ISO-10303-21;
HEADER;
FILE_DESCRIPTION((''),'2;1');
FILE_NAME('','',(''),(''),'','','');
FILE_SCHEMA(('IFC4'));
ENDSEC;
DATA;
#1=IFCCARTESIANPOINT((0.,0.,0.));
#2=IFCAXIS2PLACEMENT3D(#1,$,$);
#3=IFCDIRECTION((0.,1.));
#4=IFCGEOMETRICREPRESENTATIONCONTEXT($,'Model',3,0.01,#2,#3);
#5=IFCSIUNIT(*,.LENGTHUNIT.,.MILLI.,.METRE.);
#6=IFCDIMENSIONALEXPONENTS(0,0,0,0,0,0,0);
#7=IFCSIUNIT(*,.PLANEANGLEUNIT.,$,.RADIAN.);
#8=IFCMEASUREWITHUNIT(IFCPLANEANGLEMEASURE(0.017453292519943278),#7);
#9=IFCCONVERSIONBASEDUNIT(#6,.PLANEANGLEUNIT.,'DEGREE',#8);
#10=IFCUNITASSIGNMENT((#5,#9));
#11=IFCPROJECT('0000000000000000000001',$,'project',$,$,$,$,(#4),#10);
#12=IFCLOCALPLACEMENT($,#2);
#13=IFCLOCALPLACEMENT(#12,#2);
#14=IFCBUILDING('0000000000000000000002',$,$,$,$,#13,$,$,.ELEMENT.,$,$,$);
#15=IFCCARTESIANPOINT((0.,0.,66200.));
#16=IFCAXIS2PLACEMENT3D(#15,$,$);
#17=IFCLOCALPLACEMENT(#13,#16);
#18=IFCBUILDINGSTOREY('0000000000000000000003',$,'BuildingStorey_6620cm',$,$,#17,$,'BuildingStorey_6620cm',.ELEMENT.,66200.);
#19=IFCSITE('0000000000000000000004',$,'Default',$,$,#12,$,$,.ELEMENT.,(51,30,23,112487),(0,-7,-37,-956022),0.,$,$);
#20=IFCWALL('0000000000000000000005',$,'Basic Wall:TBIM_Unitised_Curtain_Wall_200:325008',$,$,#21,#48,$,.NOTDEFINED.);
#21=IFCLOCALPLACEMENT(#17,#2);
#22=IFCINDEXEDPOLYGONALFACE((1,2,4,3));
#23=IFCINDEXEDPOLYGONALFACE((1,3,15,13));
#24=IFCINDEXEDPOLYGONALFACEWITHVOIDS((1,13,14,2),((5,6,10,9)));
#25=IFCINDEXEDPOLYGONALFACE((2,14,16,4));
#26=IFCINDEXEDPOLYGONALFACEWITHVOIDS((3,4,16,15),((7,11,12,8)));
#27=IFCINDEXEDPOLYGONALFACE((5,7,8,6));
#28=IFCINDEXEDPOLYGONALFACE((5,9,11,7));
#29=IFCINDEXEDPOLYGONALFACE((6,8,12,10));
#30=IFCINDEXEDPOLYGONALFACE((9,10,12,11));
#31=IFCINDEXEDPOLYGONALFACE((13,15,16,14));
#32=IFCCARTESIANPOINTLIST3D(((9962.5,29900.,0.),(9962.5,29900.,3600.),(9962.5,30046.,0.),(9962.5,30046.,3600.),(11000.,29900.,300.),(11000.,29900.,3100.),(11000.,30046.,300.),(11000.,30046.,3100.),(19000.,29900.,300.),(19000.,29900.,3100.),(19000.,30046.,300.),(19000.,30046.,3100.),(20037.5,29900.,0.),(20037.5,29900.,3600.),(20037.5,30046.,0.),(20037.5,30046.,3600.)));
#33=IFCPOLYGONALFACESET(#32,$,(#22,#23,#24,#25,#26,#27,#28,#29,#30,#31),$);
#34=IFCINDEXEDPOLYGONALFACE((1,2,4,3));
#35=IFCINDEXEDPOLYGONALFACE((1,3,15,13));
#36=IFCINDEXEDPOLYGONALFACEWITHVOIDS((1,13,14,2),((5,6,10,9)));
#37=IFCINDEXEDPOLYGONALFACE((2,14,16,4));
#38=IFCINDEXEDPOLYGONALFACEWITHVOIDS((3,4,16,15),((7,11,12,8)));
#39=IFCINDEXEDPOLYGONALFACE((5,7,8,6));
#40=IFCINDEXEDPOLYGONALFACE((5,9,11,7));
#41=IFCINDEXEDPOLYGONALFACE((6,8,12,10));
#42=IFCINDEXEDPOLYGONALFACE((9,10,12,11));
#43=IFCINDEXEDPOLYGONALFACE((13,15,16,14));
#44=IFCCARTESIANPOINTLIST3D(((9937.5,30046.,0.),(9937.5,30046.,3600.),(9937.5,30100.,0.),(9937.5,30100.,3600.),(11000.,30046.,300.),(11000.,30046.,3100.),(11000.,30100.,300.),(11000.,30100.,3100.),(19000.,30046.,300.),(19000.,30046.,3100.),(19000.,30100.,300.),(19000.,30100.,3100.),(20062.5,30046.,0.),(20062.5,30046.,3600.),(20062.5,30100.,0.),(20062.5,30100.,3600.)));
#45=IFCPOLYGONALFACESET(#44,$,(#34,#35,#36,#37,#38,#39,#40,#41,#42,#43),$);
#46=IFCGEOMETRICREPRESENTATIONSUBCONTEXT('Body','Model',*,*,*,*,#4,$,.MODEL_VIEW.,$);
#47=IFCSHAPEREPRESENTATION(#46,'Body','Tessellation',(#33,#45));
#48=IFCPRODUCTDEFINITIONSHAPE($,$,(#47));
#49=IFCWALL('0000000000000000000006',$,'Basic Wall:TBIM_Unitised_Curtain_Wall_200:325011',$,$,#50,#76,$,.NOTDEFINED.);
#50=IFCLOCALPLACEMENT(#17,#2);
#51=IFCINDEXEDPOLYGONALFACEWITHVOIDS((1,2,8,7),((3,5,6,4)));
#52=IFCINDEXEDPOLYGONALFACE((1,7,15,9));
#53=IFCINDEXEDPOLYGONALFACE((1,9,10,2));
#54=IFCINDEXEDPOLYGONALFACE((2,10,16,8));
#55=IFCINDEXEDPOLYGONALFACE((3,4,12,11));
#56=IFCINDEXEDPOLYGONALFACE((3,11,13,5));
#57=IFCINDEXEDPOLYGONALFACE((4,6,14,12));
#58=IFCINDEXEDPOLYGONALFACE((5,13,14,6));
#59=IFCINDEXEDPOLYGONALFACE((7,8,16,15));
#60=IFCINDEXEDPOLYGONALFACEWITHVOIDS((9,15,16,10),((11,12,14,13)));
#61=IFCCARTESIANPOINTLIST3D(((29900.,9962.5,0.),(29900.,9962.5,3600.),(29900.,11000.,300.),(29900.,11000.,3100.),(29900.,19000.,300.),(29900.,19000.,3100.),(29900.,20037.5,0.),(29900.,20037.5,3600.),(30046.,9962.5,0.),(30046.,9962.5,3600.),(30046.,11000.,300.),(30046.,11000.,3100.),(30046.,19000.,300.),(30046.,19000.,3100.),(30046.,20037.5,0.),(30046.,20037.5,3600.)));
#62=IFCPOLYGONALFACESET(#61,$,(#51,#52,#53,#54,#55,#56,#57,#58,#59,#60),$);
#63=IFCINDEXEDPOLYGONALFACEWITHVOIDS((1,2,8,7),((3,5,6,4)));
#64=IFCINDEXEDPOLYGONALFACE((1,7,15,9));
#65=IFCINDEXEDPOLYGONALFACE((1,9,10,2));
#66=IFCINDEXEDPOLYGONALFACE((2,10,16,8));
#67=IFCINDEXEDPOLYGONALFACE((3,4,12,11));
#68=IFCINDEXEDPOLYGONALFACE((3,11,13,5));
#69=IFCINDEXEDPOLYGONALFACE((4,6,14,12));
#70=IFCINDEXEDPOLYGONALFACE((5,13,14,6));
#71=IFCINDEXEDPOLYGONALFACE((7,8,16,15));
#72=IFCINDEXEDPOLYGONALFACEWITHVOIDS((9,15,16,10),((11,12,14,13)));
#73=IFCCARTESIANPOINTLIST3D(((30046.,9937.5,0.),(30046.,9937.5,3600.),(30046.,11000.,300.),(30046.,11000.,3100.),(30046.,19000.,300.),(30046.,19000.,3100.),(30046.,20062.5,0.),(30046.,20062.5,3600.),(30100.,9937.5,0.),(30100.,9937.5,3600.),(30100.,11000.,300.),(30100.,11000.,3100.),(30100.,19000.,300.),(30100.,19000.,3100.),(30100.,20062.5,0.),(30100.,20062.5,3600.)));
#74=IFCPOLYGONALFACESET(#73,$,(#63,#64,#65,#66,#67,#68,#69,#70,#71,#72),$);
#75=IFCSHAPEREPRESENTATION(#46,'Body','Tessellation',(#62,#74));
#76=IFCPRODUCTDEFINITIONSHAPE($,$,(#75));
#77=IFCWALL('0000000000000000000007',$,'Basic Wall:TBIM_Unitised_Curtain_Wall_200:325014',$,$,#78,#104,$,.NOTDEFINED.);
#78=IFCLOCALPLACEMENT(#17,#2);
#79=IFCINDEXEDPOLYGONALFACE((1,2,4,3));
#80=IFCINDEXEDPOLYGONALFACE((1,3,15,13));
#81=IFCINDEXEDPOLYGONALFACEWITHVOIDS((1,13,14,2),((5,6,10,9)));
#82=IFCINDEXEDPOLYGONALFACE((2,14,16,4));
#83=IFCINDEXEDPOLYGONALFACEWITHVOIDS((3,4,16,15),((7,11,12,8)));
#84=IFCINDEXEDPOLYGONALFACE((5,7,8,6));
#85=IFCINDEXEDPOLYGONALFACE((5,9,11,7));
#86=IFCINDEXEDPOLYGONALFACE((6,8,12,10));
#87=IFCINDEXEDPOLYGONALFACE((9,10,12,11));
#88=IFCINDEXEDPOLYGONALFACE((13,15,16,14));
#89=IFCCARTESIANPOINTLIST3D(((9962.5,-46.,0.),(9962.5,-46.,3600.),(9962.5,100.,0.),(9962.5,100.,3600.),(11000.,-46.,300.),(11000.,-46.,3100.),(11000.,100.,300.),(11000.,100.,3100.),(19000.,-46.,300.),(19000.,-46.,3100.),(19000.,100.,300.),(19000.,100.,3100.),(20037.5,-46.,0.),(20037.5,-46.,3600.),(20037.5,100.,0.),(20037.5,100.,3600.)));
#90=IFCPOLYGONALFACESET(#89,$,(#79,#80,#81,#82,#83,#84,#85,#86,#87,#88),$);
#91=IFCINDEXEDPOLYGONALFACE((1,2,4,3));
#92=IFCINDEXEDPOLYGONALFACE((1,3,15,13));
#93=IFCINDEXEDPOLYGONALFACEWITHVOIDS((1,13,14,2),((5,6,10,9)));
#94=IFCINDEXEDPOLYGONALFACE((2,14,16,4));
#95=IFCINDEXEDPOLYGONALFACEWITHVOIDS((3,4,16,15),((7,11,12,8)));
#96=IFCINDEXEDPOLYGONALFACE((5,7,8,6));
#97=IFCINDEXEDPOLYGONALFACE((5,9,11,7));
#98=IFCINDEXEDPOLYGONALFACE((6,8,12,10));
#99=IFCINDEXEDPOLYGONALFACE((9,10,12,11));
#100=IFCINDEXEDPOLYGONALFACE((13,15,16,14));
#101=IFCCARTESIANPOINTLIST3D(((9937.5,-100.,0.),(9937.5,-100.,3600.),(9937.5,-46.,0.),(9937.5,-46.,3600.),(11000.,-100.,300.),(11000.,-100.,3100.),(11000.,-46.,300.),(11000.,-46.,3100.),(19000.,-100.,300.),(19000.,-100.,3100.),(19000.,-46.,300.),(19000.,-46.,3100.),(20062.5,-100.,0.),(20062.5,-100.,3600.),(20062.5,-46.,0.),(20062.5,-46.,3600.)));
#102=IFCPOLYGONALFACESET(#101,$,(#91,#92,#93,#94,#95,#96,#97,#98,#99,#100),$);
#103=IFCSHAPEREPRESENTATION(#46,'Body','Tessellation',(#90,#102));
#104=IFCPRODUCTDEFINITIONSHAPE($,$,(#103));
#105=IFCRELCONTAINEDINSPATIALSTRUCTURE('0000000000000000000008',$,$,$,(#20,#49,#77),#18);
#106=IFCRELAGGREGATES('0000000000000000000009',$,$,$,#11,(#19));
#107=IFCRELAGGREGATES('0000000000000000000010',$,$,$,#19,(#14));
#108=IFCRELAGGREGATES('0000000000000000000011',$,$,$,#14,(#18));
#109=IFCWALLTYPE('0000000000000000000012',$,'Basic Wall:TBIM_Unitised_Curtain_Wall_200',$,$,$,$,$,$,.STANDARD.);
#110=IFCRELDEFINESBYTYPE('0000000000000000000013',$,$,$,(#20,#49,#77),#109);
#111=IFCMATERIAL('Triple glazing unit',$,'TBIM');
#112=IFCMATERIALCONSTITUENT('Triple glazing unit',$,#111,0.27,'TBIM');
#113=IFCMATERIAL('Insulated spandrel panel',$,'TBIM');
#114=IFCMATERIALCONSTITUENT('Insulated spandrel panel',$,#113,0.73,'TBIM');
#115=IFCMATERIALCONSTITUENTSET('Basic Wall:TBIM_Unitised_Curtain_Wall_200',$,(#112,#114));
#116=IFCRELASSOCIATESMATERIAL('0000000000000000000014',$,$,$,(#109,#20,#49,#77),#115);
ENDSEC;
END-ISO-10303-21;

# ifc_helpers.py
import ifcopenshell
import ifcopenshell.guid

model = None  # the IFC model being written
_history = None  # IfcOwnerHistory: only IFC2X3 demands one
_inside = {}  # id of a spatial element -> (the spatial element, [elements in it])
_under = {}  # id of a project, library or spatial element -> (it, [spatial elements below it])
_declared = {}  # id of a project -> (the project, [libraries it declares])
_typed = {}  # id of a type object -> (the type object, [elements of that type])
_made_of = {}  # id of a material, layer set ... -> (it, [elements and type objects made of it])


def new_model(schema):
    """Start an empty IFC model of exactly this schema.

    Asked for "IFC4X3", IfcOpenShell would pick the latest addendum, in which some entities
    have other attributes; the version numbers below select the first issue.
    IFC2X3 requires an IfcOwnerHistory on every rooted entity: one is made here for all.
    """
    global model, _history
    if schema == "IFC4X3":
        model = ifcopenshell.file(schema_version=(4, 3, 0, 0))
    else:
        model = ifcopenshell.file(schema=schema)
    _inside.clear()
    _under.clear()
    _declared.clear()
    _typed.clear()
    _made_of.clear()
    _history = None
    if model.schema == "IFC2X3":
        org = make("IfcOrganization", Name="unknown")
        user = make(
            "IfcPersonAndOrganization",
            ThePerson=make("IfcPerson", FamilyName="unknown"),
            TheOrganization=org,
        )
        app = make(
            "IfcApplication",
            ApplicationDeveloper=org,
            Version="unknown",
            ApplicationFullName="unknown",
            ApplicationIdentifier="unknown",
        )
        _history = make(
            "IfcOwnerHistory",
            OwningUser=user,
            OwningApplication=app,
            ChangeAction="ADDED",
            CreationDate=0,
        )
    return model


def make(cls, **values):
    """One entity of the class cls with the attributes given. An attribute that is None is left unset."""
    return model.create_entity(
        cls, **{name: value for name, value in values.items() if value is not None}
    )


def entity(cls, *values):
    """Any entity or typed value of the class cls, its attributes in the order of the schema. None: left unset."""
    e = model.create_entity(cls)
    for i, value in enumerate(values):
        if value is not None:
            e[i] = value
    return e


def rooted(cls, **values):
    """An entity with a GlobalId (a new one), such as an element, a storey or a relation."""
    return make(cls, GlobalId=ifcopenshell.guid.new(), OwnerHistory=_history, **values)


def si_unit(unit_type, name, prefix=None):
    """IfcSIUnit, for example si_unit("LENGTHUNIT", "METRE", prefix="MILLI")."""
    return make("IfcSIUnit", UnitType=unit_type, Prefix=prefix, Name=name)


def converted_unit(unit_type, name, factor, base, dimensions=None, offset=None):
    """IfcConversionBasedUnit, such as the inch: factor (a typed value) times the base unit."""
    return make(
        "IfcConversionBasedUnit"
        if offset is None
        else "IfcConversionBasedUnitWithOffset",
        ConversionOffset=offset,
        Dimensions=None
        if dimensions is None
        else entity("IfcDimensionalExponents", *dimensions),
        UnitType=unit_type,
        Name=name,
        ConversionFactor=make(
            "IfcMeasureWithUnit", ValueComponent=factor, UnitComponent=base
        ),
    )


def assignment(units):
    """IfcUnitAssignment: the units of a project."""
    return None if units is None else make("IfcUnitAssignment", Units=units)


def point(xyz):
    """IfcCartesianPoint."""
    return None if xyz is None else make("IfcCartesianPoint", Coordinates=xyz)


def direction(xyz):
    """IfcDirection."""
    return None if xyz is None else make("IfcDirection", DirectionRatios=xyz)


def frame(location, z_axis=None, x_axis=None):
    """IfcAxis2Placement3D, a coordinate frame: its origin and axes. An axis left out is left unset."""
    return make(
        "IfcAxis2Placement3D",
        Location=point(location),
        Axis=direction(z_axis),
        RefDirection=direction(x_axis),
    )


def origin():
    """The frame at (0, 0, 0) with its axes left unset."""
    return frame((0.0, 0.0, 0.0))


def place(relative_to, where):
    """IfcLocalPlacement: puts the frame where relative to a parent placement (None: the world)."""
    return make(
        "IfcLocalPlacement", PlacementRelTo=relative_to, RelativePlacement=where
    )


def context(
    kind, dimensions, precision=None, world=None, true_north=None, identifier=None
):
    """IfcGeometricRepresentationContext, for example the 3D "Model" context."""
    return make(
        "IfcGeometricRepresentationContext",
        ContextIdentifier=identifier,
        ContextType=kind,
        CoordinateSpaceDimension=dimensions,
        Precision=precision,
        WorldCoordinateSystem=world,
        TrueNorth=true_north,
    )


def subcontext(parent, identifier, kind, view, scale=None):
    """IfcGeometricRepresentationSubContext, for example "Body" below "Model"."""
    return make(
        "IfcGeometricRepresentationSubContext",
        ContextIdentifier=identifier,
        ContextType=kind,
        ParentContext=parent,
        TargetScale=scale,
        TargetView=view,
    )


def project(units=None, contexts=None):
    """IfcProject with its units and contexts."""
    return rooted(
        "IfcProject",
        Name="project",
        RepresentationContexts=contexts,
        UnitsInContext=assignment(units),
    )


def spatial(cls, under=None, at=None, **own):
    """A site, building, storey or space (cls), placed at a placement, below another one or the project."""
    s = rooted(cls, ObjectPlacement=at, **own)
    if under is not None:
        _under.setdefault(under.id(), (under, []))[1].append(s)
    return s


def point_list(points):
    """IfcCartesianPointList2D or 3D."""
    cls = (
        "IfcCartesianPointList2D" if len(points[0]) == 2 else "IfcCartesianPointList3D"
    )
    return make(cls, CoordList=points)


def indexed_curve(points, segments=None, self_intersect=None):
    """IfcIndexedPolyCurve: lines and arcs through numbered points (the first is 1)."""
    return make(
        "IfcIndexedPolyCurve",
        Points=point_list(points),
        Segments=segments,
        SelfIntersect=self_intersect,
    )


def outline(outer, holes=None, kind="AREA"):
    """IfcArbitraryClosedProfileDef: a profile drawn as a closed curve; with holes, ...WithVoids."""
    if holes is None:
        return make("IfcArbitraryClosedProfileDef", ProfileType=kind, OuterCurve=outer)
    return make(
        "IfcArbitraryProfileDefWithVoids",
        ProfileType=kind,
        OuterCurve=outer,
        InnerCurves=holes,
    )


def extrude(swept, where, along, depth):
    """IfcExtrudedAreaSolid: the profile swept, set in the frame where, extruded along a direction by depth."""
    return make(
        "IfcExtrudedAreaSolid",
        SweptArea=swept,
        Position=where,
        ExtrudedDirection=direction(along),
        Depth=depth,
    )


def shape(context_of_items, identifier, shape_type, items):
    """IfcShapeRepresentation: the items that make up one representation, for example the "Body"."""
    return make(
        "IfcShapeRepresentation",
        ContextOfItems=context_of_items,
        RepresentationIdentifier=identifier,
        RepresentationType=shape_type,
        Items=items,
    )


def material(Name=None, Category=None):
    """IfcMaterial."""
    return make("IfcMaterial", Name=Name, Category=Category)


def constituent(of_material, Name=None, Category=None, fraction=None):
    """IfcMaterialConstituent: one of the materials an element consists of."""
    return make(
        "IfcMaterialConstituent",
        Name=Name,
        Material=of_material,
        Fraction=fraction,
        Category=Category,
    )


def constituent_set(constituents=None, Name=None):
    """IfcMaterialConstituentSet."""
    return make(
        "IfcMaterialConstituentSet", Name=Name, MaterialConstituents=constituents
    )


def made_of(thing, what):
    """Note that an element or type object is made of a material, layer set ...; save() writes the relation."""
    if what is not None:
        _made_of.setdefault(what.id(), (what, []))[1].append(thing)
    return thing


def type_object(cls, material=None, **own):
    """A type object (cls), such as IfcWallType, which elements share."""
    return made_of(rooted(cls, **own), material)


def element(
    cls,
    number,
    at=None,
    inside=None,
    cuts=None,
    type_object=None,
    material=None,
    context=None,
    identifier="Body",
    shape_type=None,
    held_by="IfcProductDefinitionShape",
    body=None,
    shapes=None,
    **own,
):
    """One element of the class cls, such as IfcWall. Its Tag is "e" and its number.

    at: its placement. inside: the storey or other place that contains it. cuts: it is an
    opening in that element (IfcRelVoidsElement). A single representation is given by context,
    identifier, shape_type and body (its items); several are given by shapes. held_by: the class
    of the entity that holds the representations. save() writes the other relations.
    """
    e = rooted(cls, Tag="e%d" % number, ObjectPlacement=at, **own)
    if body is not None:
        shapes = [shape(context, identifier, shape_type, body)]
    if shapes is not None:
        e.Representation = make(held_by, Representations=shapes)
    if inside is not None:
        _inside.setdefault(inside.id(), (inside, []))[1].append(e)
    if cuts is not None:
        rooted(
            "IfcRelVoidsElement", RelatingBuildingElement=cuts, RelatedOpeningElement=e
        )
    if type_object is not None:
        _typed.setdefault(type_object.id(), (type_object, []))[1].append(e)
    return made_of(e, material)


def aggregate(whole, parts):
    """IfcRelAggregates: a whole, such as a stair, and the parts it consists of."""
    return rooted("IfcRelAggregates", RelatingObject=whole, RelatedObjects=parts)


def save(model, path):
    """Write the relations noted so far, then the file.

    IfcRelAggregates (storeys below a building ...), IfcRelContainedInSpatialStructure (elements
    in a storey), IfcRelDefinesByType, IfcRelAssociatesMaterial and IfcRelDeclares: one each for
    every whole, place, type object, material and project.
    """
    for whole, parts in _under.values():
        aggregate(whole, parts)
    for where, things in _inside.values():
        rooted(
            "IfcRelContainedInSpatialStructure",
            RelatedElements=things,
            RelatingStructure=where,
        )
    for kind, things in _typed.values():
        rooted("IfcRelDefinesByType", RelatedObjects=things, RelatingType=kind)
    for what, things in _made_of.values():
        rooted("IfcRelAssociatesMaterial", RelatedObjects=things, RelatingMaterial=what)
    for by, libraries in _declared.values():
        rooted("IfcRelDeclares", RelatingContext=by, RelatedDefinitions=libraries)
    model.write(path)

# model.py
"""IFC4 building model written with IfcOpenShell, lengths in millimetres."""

from ifc_helpers import new_model, entity, si_unit, converted_unit, direction, frame, origin, place, context, subcontext, project, spatial, indexed_curve, outline, extrude, material, constituent, constituent_set, type_object, element, save


model = new_model("IFC4")

# Units and contexts
model_context = context("Model", 3, precision=0.01, world=origin(), true_north=direction((0.0, 1.0)))
body_context = subcontext(model_context, "Body", "Model", "MODEL_VIEW")
ifc_project = project(units=[si_unit("LENGTHUNIT", "METRE", prefix="MILLI"), converted_unit("PLANEANGLEUNIT", "DEGREE", entity("IfcPlaneAngleMeasure", 0.017453292519943278), si_unit("PLANEANGLEUNIT", "RADIAN"), dimensions=[0, 0, 0, 0, 0, 0, 0])], contexts=[model_context])

# Site, building, storey
site_placement = place(None, origin())
site = spatial("IfcSite", under=ifc_project, at=site_placement, Name="Default", CompositionType="ELEMENT", RefLatitude=(51, 30, 23, 112487), RefLongitude=(0, -7, -37, -956022), RefElevation=0.0)
building_placement = place(site_placement, origin())
building = spatial("IfcBuilding", under=site, at=building_placement, CompositionType="ELEMENT")
storey_placement = place(building_placement, frame((0.0, 0.0, 66200.0)))
storey = spatial("IfcBuildingStorey", under=building, at=storey_placement, Name="BuildingStorey_6620cm", LongName="BuildingStorey_6620cm", CompositionType="ELEMENT", Elevation=66200.0)

# Walls, openings
ifc_material_1 = material(Name="Triple glazing unit", Category="TBIM")
ifc_constituent_1 = constituent(ifc_material_1, Name="Triple glazing unit", Category="TBIM", fraction=0.27)
ifc_material_2 = material(Name="Insulated spandrel panel", Category="TBIM")
ifc_constituent_2 = constituent(ifc_material_2, Name="Insulated spandrel panel", Category="TBIM", fraction=0.73)
ifc_constituent_set_1 = constituent_set(constituents=[ifc_constituent_1, ifc_constituent_2], Name="Basic Wall:TBIM_Unitised_Curtain_Wall_200")
wall_type_1 = type_object("IfcWallType", Name="Basic Wall:TBIM_Unitised_Curtain_Wall_200", PredefinedType="STANDARD", material=ifc_constituent_set_1)
wall_1_placement = place(storey_placement, frame((9937.5, 30000.0, 0.0)))
wall_1 = element("IfcWall", 1, at=wall_1_placement, inside=storey, type_object=wall_type_1, material=ifc_constituent_set_1, Name="Basic Wall:TBIM_Unitised_Curtain_Wall_200:325008", PredefinedType="NOTDEFINED", context=body_context, shape_type="SweptSolid", body=[
    extrude(outline(indexed_curve([(-1800.0, -5037.5), (1800.0, -5037.5), (1800.0, -4937.5), (1800.0, 4937.5), (1800.0, 5037.5), (-1800.0, 5037.5), (-1800.0, 4937.5), (-1800.0, -4937.5), (-1800.0, -5037.5)], self_intersect=False), holes=[indexed_curve([(1300.0, -4000.0), (-1500.0, -4000.0), (-1500.0, 4000.0), (1300.0, 4000.0), (1300.0, -4000.0)], self_intersect=False)]), frame((5062.5, -100.0, 1800.0), z_axis=(0.0, 1.0, 0.0), x_axis=(0.0, 0.0, 1.0)), (0.0, 0.0, 1.0), 146.0),
    extrude(outline(indexed_curve([(-1800.0, -5062.5), (1800.0, -5062.5), (1800.0, 5062.5), (-1800.0, 5062.5), (-1800.0, -5062.5)], self_intersect=False), holes=[indexed_curve([(-1500.0, -4000.0), (-1500.0, 4000.0), (1300.0, 4000.0), (1300.0, -4000.0), (-1500.0, -4000.0)], self_intersect=False)]), frame((5062.5, 46.0, 1800.0), z_axis=(0.0, 1.0, 0.0), x_axis=(0.0, 0.0, 1.0)), (0.0, 0.0, 1.0), 54.0),
])
opening_1_placement = place(wall_1_placement, frame((1062.5, -100.0, 300.0)))
element("IfcOpeningElement", 2, at=opening_1_placement, cuts=wall_1, PredefinedType="OPENING", context=body_context, shape_type="SweptSolid", body=[
    extrude(outline(indexed_curve([(2800.0, 0.0), (2800.0, 8000.0), (0.0, 8000.0), (0.0, 0.0), (2800.0, 0.0)], self_intersect=False)), frame((0.0, 0.0, 0.0), z_axis=(0.0, 1.0, 0.0), x_axis=(0.0, 0.0, 1.0)), (0.0, 0.0, 1.0), 200.0),
])
wall_2_placement = place(storey_placement, frame((30000.0, 9937.5, 0.0), z_axis=(0.0, 0.0, 1.0), x_axis=(0.0, 1.0, 0.0)))
wall_2 = element("IfcWall", 3, at=wall_2_placement, inside=storey, type_object=wall_type_1, material=ifc_constituent_set_1, Name="Basic Wall:TBIM_Unitised_Curtain_Wall_200:325011", PredefinedType="NOTDEFINED", context=body_context, shape_type="SweptSolid", body=[
    extrude(outline(indexed_curve([(-5037.5, -1800.0), (-4937.5, -1800.0), (4937.5, -1800.0), (5037.5, -1800.0), (5037.5, 1800.0), (4937.5, 1800.0), (-4937.5, 1800.0), (-5037.5, 1800.0), (-5037.5, -1800.0)], self_intersect=False), holes=[indexed_curve([(-4000.0, 1300.0), (4000.0, 1300.0), (4000.0, -1500.0), (-4000.0, -1500.0), (-4000.0, 1300.0)], self_intersect=False)]), frame((5062.5, 100.0, 1800.0), z_axis=(0.0, -1.0, 0.0), x_axis=(1.0, 0.0, 0.0)), (0.0, 0.0, 1.0), 146.0),
    extrude(outline(indexed_curve([(-1800.0, -5062.5), (1800.0, -5062.5), (1800.0, 5062.5), (-1800.0, 5062.5), (-1800.0, -5062.5)], self_intersect=False), holes=[indexed_curve([(1300.0, 4000.0), (1300.0, -4000.0), (-1500.0, -4000.0), (-1500.0, 4000.0), (1300.0, 4000.0)], self_intersect=False)]), frame((5062.5, -46.0, 1800.0), z_axis=(0.0, -1.0, 0.0), x_axis=(0.0, 0.0, 1.0)), (0.0, 0.0, 1.0), 54.0),
])
opening_2_placement = place(wall_2_placement, frame((1062.5, -100.0, 300.0)))
element("IfcOpeningElement", 4, at=opening_2_placement, cuts=wall_2, PredefinedType="OPENING", context=body_context, shape_type="SweptSolid", body=[
    extrude(outline(indexed_curve([(2800.0, 0.0), (2800.0, 8000.0), (0.0, 8000.0), (0.0, 0.0), (2800.0, 0.0)], self_intersect=False)), frame((0.0, 0.0, 0.0), z_axis=(0.0, 1.0, 0.0), x_axis=(0.0, 0.0, 1.0)), (0.0, 0.0, 1.0), 200.0),
])
wall_3_placement = place(storey_placement, frame((9937.5, 0.0, 0.0)))
wall_3 = element("IfcWall", 5, at=wall_3_placement, inside=storey, type_object=wall_type_1, material=ifc_constituent_set_1, Name="Basic Wall:TBIM_Unitised_Curtain_Wall_200:325014", PredefinedType="NOTDEFINED", context=body_context, shape_type="SweptSolid", body=[
    extrude(outline(indexed_curve([(-1800.0, -5037.5), (1800.0, -5037.5), (1800.0, 5037.5), (-1800.0, 5037.5), (-1800.0, -5037.5)], self_intersect=False), holes=[indexed_curve([(-1500.0, -4000.0), (-1500.0, 4000.0), (1300.0, 4000.0), (1300.0, -4000.0), (-1500.0, -4000.0)], self_intersect=False)]), frame((5062.5, -46.0, 1800.0), z_axis=(0.0, 1.0, 0.0), x_axis=(0.0, 0.0, 1.0)), (0.0, 0.0, 1.0), 146.0),
    extrude(outline(indexed_curve([(-1800.0, -5062.5), (1800.0, -5062.5), (1800.0, 5062.5), (-1800.0, 5062.5), (-1800.0, -5062.5)], self_intersect=False), holes=[indexed_curve([(1300.0, -4000.0), (-1500.0, -4000.0), (-1500.0, 4000.0), (1300.0, 4000.0), (1300.0, -4000.0)], self_intersect=False)]), frame((5062.5, -100.0, 1800.0), z_axis=(0.0, 1.0, 0.0), x_axis=(0.0, 0.0, 1.0)), (0.0, 0.0, 1.0), 54.0),
])
opening_3_placement = place(wall_3_placement, frame((1062.5, -100.0, 300.0)))
element("IfcOpeningElement", 6, at=opening_3_placement, cuts=wall_3, PredefinedType="OPENING", context=body_context, shape_type="SweptSolid", body=[
    extrude(outline(indexed_curve([(2800.0, 0.0), (2800.0, 8000.0), (0.0, 8000.0), (0.0, 0.0), (2800.0, 0.0)], self_intersect=False)), frame((0.0, 0.0, 0.0), z_axis=(0.0, 1.0, 0.0), x_axis=(0.0, 0.0, 1.0)), (0.0, 0.0, 1.0), 200.0),
])

save(model, "model.ifc")
